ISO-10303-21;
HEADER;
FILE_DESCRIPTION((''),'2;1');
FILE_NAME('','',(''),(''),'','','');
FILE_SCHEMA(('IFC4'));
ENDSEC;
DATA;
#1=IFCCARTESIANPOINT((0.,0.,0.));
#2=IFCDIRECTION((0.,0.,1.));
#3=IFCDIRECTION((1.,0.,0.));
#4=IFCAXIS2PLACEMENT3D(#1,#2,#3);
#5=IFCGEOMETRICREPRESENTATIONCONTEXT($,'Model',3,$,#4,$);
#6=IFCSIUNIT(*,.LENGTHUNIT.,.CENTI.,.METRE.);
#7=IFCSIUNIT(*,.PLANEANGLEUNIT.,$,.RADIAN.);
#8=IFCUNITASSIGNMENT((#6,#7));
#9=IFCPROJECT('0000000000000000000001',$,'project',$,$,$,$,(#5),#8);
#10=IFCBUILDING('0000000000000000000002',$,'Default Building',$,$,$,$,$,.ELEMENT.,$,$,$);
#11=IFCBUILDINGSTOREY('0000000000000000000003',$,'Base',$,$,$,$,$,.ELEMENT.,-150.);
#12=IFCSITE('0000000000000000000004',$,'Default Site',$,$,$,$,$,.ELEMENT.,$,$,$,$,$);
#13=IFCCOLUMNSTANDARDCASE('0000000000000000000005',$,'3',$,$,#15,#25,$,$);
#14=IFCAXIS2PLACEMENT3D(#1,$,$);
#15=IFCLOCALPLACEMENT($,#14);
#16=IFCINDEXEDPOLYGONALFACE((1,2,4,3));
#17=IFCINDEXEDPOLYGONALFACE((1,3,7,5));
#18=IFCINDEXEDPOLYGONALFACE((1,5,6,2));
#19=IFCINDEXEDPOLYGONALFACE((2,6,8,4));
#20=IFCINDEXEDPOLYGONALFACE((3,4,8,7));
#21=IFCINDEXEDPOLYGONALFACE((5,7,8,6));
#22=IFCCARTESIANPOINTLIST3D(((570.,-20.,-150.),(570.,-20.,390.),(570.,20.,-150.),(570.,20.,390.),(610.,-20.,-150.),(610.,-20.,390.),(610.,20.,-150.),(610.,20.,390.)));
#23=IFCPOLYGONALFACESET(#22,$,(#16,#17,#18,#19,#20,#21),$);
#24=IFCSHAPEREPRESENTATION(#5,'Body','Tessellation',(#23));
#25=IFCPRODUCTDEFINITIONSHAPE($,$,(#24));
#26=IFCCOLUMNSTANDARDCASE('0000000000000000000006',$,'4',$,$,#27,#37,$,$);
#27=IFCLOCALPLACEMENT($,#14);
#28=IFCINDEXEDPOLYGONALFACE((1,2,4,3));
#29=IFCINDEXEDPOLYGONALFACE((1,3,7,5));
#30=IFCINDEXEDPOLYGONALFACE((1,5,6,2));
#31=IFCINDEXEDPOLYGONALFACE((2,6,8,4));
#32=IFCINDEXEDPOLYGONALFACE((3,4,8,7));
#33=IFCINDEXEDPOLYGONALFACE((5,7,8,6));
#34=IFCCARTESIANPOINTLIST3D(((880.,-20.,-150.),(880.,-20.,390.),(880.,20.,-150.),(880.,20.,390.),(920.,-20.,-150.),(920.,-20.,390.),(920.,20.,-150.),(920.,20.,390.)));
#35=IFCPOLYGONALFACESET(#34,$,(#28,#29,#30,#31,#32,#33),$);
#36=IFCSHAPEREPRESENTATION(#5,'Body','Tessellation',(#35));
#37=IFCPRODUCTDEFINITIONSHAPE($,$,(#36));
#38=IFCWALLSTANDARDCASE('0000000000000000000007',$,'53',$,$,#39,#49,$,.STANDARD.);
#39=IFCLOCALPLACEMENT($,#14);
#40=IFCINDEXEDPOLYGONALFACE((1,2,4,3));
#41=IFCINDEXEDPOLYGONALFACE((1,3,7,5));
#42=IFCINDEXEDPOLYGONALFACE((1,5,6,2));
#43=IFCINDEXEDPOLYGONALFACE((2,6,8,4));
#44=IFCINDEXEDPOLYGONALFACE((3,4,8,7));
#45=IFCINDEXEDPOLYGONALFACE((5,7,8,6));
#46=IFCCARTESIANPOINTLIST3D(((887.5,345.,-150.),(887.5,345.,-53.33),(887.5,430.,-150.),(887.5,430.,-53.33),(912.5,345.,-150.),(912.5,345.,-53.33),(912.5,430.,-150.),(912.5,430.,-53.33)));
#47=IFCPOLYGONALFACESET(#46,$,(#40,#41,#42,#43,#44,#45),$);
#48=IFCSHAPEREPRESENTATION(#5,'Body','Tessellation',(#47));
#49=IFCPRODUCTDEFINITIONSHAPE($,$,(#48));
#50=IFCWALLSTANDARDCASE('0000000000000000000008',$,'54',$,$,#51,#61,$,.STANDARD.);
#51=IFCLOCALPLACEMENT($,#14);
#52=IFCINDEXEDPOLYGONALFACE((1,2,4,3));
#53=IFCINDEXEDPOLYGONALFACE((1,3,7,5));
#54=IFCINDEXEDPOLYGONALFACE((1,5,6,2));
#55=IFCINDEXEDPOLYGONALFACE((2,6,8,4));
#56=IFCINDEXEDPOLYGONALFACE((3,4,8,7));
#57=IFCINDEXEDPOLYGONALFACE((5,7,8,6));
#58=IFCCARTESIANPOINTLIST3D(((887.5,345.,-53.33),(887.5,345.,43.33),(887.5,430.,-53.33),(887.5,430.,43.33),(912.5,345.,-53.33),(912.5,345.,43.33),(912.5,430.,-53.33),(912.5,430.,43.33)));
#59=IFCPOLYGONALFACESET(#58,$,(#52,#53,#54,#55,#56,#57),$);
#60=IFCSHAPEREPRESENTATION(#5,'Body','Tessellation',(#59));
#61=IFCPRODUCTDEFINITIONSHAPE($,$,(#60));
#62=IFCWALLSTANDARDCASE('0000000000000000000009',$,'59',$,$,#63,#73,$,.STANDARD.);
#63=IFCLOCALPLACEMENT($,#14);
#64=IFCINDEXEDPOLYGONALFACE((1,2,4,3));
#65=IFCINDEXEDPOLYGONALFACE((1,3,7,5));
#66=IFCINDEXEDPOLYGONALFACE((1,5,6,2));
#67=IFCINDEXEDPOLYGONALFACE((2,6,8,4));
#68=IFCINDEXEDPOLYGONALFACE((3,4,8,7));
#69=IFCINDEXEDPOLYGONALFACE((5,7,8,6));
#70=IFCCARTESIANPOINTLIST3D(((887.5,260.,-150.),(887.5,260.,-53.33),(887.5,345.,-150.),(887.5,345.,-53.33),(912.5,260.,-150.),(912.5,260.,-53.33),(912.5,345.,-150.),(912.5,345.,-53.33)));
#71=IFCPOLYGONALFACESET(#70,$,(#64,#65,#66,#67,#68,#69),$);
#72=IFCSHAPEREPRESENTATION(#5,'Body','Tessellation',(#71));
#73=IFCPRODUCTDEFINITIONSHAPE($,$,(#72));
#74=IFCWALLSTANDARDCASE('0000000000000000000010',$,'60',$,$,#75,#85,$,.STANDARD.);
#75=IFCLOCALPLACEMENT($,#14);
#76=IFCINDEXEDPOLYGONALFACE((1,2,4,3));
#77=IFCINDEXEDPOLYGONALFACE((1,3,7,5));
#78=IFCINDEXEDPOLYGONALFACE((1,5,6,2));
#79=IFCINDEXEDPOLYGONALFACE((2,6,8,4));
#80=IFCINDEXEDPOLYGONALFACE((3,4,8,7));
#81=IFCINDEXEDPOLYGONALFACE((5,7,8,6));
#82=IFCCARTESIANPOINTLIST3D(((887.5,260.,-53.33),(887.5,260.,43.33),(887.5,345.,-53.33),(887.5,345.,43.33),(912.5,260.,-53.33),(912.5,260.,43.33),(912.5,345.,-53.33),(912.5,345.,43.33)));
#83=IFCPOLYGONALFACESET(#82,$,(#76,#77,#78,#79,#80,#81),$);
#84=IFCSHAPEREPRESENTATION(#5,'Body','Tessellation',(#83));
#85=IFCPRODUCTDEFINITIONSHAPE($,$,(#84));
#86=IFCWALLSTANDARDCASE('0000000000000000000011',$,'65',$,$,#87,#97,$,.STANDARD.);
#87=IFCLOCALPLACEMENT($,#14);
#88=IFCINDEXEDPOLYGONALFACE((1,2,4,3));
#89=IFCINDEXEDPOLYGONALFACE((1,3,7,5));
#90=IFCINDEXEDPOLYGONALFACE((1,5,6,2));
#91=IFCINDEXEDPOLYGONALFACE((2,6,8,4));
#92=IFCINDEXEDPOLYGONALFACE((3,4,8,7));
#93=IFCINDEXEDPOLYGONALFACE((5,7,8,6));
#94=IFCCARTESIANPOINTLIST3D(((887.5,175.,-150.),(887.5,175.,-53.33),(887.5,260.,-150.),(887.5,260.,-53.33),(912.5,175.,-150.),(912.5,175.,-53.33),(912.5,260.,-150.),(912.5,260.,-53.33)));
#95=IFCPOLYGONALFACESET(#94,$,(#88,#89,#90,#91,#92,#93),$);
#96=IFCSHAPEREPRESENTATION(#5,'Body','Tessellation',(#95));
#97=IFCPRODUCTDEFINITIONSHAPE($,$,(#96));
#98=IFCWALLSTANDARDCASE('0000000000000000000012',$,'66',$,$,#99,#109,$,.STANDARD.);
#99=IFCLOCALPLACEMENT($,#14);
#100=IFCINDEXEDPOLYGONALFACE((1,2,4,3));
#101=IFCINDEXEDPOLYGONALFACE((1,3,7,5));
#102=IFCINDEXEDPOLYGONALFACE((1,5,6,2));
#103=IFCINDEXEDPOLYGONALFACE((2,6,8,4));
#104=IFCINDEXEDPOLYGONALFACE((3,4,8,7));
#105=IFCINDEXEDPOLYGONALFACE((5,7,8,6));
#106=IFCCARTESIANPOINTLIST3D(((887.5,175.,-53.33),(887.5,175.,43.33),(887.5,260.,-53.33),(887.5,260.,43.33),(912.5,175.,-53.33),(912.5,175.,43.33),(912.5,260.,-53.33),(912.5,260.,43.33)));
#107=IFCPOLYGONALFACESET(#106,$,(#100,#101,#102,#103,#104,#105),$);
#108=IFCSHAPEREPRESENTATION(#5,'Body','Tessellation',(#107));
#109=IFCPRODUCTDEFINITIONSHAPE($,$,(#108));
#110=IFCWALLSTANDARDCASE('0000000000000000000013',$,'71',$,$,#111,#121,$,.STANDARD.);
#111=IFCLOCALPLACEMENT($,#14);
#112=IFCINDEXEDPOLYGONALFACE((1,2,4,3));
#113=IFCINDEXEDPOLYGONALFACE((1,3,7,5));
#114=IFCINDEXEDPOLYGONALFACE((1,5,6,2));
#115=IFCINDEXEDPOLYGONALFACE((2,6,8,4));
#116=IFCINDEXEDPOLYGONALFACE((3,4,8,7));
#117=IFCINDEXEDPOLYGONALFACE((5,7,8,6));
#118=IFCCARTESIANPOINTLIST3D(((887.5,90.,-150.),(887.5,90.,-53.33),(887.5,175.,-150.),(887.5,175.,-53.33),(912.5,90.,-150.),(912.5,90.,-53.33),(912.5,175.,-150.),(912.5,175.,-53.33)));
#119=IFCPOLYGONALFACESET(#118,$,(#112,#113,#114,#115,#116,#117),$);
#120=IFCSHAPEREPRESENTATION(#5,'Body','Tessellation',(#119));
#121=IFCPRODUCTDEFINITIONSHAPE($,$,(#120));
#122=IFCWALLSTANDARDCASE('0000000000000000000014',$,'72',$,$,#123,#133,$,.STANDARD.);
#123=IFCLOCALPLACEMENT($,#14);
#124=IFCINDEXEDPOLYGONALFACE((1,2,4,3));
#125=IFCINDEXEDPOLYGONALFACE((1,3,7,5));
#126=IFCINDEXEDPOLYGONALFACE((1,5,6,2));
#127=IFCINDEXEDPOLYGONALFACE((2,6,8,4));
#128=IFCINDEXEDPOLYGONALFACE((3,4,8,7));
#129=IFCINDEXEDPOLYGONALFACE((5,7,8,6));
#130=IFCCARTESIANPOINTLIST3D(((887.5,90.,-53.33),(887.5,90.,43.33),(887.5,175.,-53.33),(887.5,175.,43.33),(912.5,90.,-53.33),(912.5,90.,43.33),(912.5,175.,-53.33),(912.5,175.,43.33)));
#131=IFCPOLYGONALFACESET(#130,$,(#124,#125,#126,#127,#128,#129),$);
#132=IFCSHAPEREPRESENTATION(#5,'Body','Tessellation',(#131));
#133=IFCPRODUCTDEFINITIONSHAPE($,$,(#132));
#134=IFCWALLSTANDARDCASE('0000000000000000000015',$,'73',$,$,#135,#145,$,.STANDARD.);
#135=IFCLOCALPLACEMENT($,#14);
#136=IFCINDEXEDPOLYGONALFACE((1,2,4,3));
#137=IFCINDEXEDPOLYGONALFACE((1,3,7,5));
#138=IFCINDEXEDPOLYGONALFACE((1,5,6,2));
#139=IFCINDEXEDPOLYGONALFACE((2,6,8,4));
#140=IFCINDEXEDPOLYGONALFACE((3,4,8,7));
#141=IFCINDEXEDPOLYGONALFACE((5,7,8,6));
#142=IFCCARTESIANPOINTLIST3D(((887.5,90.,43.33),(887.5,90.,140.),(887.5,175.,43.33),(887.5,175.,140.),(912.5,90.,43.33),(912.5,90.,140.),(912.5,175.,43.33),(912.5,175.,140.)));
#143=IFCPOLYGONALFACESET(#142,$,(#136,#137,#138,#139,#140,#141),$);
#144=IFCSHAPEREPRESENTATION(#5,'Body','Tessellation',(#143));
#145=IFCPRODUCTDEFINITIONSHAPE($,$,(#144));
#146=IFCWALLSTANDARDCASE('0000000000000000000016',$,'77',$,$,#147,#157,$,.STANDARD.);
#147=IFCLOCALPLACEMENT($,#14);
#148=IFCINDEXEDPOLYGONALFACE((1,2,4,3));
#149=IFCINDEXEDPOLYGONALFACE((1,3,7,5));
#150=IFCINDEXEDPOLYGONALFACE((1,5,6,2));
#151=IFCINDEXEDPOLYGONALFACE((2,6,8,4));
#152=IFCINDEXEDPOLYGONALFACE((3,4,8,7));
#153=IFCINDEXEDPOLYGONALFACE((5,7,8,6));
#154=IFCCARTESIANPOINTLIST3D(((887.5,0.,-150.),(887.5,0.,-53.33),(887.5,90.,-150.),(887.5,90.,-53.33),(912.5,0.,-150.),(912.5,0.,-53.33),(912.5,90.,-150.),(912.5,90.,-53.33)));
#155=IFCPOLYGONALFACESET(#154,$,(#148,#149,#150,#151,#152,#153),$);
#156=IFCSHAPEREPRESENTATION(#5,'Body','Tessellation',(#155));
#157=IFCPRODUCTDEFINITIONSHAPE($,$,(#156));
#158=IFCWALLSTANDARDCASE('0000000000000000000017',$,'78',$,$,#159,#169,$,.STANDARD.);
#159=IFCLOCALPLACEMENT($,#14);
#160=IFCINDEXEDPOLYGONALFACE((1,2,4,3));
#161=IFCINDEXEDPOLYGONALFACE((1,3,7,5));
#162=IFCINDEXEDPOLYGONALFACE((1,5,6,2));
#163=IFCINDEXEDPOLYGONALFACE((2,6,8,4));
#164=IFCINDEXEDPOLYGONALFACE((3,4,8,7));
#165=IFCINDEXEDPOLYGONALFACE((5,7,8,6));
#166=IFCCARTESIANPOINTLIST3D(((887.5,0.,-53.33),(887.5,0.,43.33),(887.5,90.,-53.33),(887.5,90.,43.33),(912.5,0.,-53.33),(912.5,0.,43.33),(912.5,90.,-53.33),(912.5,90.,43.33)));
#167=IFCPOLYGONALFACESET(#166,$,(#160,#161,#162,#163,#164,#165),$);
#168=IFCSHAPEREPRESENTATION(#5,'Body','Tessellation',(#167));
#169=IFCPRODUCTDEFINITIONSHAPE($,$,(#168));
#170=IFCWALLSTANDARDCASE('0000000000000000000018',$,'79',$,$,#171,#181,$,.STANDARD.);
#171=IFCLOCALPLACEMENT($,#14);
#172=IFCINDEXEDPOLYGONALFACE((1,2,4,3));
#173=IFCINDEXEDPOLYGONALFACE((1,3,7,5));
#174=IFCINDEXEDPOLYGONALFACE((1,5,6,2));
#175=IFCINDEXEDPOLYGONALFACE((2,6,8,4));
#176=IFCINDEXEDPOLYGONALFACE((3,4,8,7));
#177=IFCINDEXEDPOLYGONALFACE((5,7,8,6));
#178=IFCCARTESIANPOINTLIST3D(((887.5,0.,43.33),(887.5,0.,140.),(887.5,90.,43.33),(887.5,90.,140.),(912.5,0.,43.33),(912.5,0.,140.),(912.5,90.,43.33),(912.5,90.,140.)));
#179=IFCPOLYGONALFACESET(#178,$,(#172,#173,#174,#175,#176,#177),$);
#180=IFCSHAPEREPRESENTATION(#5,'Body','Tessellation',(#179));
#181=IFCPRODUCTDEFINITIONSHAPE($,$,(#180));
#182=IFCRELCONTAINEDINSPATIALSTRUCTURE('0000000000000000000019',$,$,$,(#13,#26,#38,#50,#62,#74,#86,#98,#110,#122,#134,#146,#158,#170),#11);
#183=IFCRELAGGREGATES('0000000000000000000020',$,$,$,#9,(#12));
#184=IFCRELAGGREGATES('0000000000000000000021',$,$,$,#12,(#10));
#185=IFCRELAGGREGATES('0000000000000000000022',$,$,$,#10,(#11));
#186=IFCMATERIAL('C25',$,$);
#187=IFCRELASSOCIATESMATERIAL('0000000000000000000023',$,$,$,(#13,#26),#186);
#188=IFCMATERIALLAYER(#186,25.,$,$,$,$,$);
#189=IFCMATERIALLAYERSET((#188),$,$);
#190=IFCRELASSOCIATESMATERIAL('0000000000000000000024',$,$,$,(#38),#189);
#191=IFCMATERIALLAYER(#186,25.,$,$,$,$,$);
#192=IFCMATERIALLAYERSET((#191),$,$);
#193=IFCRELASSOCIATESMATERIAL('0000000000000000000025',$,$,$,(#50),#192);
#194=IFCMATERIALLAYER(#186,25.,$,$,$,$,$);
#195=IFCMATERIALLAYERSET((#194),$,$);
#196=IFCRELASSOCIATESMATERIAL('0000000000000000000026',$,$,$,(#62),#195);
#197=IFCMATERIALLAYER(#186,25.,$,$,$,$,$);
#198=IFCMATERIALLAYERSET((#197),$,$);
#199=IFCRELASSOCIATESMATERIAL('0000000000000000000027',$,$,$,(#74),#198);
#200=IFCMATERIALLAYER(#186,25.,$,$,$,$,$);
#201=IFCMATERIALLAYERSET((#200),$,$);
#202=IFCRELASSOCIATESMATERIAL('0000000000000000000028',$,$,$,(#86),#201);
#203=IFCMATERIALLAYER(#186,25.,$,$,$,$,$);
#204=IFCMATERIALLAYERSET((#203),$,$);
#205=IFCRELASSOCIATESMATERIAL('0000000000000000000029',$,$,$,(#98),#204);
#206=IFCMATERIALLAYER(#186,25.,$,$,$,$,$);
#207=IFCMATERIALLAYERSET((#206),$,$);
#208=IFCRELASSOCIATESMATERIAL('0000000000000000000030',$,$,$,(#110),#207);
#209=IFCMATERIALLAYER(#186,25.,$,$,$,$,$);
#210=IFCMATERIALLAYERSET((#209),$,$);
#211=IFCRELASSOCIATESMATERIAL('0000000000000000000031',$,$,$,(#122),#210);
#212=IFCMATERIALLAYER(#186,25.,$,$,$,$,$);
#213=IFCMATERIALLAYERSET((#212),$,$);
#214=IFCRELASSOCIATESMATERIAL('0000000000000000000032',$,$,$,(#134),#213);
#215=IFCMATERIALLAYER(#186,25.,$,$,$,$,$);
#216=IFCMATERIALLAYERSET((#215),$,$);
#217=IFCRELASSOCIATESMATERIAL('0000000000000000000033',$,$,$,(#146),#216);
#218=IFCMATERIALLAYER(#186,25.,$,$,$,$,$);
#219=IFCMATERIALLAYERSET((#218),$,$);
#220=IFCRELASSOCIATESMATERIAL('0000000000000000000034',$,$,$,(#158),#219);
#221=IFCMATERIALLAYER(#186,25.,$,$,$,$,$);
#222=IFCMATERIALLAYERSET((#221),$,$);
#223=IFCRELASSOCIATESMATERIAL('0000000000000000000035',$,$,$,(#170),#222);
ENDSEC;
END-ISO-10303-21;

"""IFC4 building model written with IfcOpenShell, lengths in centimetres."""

from ifc_helpers import new_model, si_unit, frame, origin_with_axes, origin_2d_with_axis, place, context, project, spatial, rectangle, extrude, material, layer, layer_set, layer_usage, material_profile, profile_set, profile_usage, element, save


model = new_model("IFC4")

# Units and contexts
model_context = context("Model", 3, world=origin_with_axes())
ifc_project = project(units=[si_unit("LENGTHUNIT", "METRE", prefix="CENTI"), si_unit("PLANEANGLEUNIT", "RADIAN")], contexts=[model_context])

# Site, building, storey
site = spatial("IfcSite", under=ifc_project, Name="Default Site", CompositionType="ELEMENT")
building = spatial("IfcBuilding", under=site, Name="Default Building", CompositionType="ELEMENT")
storey = spatial("IfcBuildingStorey", under=building, Name="Base", CompositionType="ELEMENT", Elevation=-150.0)

# Columns
ifc_material = material(Name="C25")
ifc_material_profile_1 = material_profile(ifc_material, rectangle(XDim=40.0, YDim=40.0, at=origin_2d_with_axis()))
ifc_profile_set_1 = profile_set([ifc_material_profile_1])
ifc_profile_usage_1 = profile_usage(ifc_profile_set_1, cardinal=10)
column_1_placement = place(None, frame((590.0, 0.0, -150.0), z_axis=(0.0, 0.0, 1.0), x_axis=(0.0, -1.0, 0.0)))
element("IfcColumnStandardCase", 1, at=column_1_placement, inside=storey, material=ifc_profile_usage_1, Name="3", context=model_context, shape_type="SweptSolid", body=[
    extrude(rectangle(XDim=40.0, YDim=40.0, at=origin_2d_with_axis()), origin_with_axes(), (0.0, 0.0, 1.0), 540.0),
])
ifc_material_profile_2 = material_profile(ifc_material, rectangle(XDim=40.0, YDim=40.0, at=origin_2d_with_axis()))
ifc_profile_set_2 = profile_set([ifc_material_profile_2])
ifc_profile_usage_2 = profile_usage(ifc_profile_set_2, cardinal=10)
column_2_placement = place(None, frame((900.0, 0.0, -150.0), z_axis=(0.0, 0.0, 1.0), x_axis=(0.0, -1.0, 0.0)))
element("IfcColumnStandardCase", 2, at=column_2_placement, inside=storey, material=ifc_profile_usage_2, Name="4", context=model_context, shape_type="SweptSolid", body=[
    extrude(rectangle(XDim=40.0, YDim=40.0, at=origin_2d_with_axis()), origin_with_axes(), (0.0, 0.0, 1.0), 540.0),
])

# Walls
ifc_layer_1 = layer(ifc_material, 25.0)
ifc_layer_set_1 = layer_set([ifc_layer_1])
ifc_layer_usage_1 = layer_usage(ifc_layer_set_1, "AXIS2", "POSITIVE", -25.0)
wall_1_placement = place(None, frame((900.0, 387.5, -150.0), z_axis=(0.0, 0.0, 1.0), x_axis=(0.0, -1.0, 0.0)))
element("IfcWallStandardCase", 3, at=wall_1_placement, inside=storey, material=ifc_layer_usage_1, Name="53", PredefinedType="STANDARD", context=model_context, shape_type="SweptSolid", body=[
    extrude(rectangle(XDim=85.0, YDim=25.0, at=origin_2d_with_axis()), origin_with_axes(), (0.0, 0.0, 1.0), 96.67),
])
ifc_layer_2 = layer(ifc_material, 25.0)
ifc_layer_set_2 = layer_set([ifc_layer_2])
ifc_layer_usage_2 = layer_usage(ifc_layer_set_2, "AXIS2", "POSITIVE", -25.0)
wall_2_placement = place(None, frame((900.0, 387.5, -53.33), z_axis=(0.0, 0.0, 1.0), x_axis=(0.0, -1.0, 0.0)))
element("IfcWallStandardCase", 4, at=wall_2_placement, inside=storey, material=ifc_layer_usage_2, Name="54", PredefinedType="STANDARD", context=model_context, shape_type="SweptSolid", body=[
    extrude(rectangle(XDim=85.0, YDim=25.0, at=origin_2d_with_axis()), origin_with_axes(), (0.0, 0.0, 1.0), 96.67),
])
ifc_layer_3 = layer(ifc_material, 25.0)
ifc_layer_set_3 = layer_set([ifc_layer_3])
ifc_layer_usage_3 = layer_usage(ifc_layer_set_3, "AXIS2", "POSITIVE", -25.0)
wall_3_placement = place(None, frame((900.0, 302.5, -150.0), z_axis=(0.0, 0.0, 1.0), x_axis=(0.0, -1.0, 0.0)))
element("IfcWallStandardCase", 5, at=wall_3_placement, inside=storey, material=ifc_layer_usage_3, Name="59", PredefinedType="STANDARD", context=model_context, shape_type="SweptSolid", body=[
    extrude(rectangle(XDim=85.0, YDim=25.0, at=origin_2d_with_axis()), origin_with_axes(), (0.0, 0.0, 1.0), 96.67),
])
ifc_layer_4 = layer(ifc_material, 25.0)
ifc_layer_set_4 = layer_set([ifc_layer_4])
ifc_layer_usage_4 = layer_usage(ifc_layer_set_4, "AXIS2", "POSITIVE", -25.0)
wall_4_placement = place(None, frame((900.0, 302.5, -53.33), z_axis=(0.0, 0.0, 1.0), x_axis=(0.0, -1.0, 0.0)))
element("IfcWallStandardCase", 6, at=wall_4_placement, inside=storey, material=ifc_layer_usage_4, Name="60", PredefinedType="STANDARD", context=model_context, shape_type="SweptSolid", body=[
    extrude(rectangle(XDim=85.0, YDim=25.0, at=origin_2d_with_axis()), origin_with_axes(), (0.0, 0.0, 1.0), 96.67),
])
ifc_layer_5 = layer(ifc_material, 25.0)
ifc_layer_set_5 = layer_set([ifc_layer_5])
ifc_layer_usage_5 = layer_usage(ifc_layer_set_5, "AXIS2", "POSITIVE", -25.0)
wall_5_placement = place(None, frame((900.0, 217.5, -150.0), z_axis=(0.0, 0.0, 1.0), x_axis=(0.0, -1.0, 0.0)))
element("IfcWallStandardCase", 7, at=wall_5_placement, inside=storey, material=ifc_layer_usage_5, Name="65", PredefinedType="STANDARD", context=model_context, shape_type="SweptSolid", body=[
    extrude(rectangle(XDim=85.0, YDim=25.0, at=origin_2d_with_axis()), origin_with_axes(), (0.0, 0.0, 1.0), 96.67),
])
ifc_layer_6 = layer(ifc_material, 25.0)
ifc_layer_set_6 = layer_set([ifc_layer_6])
ifc_layer_usage_6 = layer_usage(ifc_layer_set_6, "AXIS2", "POSITIVE", -25.0)
wall_6_placement = place(None, frame((900.0, 217.5, -53.33), z_axis=(0.0, 0.0, 1.0), x_axis=(0.0, -1.0, 0.0)))
element("IfcWallStandardCase", 8, at=wall_6_placement, inside=storey, material=ifc_layer_usage_6, Name="66", PredefinedType="STANDARD", context=model_context, shape_type="SweptSolid", body=[
    extrude(rectangle(XDim=85.0, YDim=25.0, at=origin_2d_with_axis()), origin_with_axes(), (0.0, 0.0, 1.0), 96.67),
])
ifc_layer_7 = layer(ifc_material, 25.0)
ifc_layer_set_7 = layer_set([ifc_layer_7])
ifc_layer_usage_7 = layer_usage(ifc_layer_set_7, "AXIS2", "POSITIVE", -25.0)
wall_7_placement = place(None, frame((900.0, 132.5, -150.0), z_axis=(0.0, 0.0, 1.0), x_axis=(0.0, -1.0, 0.0)))
element("IfcWallStandardCase", 9, at=wall_7_placement, inside=storey, material=ifc_layer_usage_7, Name="71", PredefinedType="STANDARD", context=model_context, shape_type="SweptSolid", body=[
    extrude(rectangle(XDim=85.0, YDim=25.0, at=origin_2d_with_axis()), origin_with_axes(), (0.0, 0.0, 1.0), 96.67),
])
ifc_layer_8 = layer(ifc_material, 25.0)
ifc_layer_set_8 = layer_set([ifc_layer_8])
ifc_layer_usage_8 = layer_usage(ifc_layer_set_8, "AXIS2", "POSITIVE", -25.0)
wall_8_placement = place(None, frame((900.0, 132.5, -53.33), z_axis=(0.0, 0.0, 1.0), x_axis=(0.0, -1.0, 0.0)))
element("IfcWallStandardCase", 10, at=wall_8_placement, inside=storey, material=ifc_layer_usage_8, Name="72", PredefinedType="STANDARD", context=model_context, shape_type="SweptSolid", body=[
    extrude(rectangle(XDim=85.0, YDim=25.0, at=origin_2d_with_axis()), origin_with_axes(), (0.0, 0.0, 1.0), 96.67),
])
ifc_layer_9 = layer(ifc_material, 25.0)
ifc_layer_set_9 = layer_set([ifc_layer_9])
ifc_layer_usage_9 = layer_usage(ifc_layer_set_9, "AXIS2", "POSITIVE", -25.0)
wall_9_placement = place(None, frame((900.0, 132.5, 43.33), z_axis=(0.0, 0.0, 1.0), x_axis=(0.0, -1.0, 0.0)))
element("IfcWallStandardCase", 11, at=wall_9_placement, inside=storey, material=ifc_layer_usage_9, Name="73", PredefinedType="STANDARD", context=model_context, shape_type="SweptSolid", body=[
    extrude(rectangle(XDim=85.0, YDim=25.0, at=origin_2d_with_axis()), origin_with_axes(), (0.0, 0.0, 1.0), 96.67),
])
ifc_layer_10 = layer(ifc_material, 25.0)
ifc_layer_set_10 = layer_set([ifc_layer_10])
ifc_layer_usage_10 = layer_usage(ifc_layer_set_10, "AXIS2", "POSITIVE", -25.0)
wall_10_placement = place(None, frame((900.0, 45.0, -150.0), z_axis=(0.0, 0.0, 1.0), x_axis=(0.0, -1.0, 0.0)))
element("IfcWallStandardCase", 12, at=wall_10_placement, inside=storey, material=ifc_layer_usage_10, Name="77", PredefinedType="STANDARD", context=model_context, shape_type="SweptSolid", body=[
    extrude(rectangle(XDim=90.0, YDim=25.0, at=origin_2d_with_axis()), origin_with_axes(), (0.0, 0.0, 1.0), 96.67),
])
ifc_layer_11 = layer(ifc_material, 25.0)
ifc_layer_set_11 = layer_set([ifc_layer_11])
ifc_layer_usage_11 = layer_usage(ifc_layer_set_11, "AXIS2", "POSITIVE", -25.0)
wall_11_placement = place(None, frame((900.0, 45.0, -53.33), z_axis=(0.0, 0.0, 1.0), x_axis=(0.0, -1.0, 0.0)))
element("IfcWallStandardCase", 13, at=wall_11_placement, inside=storey, material=ifc_layer_usage_11, Name="78", PredefinedType="STANDARD", context=model_context, shape_type="SweptSolid", body=[
    extrude(rectangle(XDim=90.0, YDim=25.0, at=origin_2d_with_axis()), origin_with_axes(), (0.0, 0.0, 1.0), 96.67),
])
ifc_layer_12 = layer(ifc_material, 25.0)
ifc_layer_set_12 = layer_set([ifc_layer_12])
ifc_layer_usage_12 = layer_usage(ifc_layer_set_12, "AXIS2", "POSITIVE", -25.0)
wall_12_placement = place(None, frame((900.0, 45.0, 43.33), z_axis=(0.0, 0.0, 1.0), x_axis=(0.0, -1.0, 0.0)))
element("IfcWallStandardCase", 14, at=wall_12_placement, inside=storey, material=ifc_layer_usage_12, Name="79", PredefinedType="STANDARD", context=model_context, shape_type="SweptSolid", body=[
    extrude(rectangle(XDim=90.0, YDim=25.0, at=origin_2d_with_axis()), origin_with_axes(), (0.0, 0.0, 1.0), 96.67),
])

save(model, "model.ifc")
